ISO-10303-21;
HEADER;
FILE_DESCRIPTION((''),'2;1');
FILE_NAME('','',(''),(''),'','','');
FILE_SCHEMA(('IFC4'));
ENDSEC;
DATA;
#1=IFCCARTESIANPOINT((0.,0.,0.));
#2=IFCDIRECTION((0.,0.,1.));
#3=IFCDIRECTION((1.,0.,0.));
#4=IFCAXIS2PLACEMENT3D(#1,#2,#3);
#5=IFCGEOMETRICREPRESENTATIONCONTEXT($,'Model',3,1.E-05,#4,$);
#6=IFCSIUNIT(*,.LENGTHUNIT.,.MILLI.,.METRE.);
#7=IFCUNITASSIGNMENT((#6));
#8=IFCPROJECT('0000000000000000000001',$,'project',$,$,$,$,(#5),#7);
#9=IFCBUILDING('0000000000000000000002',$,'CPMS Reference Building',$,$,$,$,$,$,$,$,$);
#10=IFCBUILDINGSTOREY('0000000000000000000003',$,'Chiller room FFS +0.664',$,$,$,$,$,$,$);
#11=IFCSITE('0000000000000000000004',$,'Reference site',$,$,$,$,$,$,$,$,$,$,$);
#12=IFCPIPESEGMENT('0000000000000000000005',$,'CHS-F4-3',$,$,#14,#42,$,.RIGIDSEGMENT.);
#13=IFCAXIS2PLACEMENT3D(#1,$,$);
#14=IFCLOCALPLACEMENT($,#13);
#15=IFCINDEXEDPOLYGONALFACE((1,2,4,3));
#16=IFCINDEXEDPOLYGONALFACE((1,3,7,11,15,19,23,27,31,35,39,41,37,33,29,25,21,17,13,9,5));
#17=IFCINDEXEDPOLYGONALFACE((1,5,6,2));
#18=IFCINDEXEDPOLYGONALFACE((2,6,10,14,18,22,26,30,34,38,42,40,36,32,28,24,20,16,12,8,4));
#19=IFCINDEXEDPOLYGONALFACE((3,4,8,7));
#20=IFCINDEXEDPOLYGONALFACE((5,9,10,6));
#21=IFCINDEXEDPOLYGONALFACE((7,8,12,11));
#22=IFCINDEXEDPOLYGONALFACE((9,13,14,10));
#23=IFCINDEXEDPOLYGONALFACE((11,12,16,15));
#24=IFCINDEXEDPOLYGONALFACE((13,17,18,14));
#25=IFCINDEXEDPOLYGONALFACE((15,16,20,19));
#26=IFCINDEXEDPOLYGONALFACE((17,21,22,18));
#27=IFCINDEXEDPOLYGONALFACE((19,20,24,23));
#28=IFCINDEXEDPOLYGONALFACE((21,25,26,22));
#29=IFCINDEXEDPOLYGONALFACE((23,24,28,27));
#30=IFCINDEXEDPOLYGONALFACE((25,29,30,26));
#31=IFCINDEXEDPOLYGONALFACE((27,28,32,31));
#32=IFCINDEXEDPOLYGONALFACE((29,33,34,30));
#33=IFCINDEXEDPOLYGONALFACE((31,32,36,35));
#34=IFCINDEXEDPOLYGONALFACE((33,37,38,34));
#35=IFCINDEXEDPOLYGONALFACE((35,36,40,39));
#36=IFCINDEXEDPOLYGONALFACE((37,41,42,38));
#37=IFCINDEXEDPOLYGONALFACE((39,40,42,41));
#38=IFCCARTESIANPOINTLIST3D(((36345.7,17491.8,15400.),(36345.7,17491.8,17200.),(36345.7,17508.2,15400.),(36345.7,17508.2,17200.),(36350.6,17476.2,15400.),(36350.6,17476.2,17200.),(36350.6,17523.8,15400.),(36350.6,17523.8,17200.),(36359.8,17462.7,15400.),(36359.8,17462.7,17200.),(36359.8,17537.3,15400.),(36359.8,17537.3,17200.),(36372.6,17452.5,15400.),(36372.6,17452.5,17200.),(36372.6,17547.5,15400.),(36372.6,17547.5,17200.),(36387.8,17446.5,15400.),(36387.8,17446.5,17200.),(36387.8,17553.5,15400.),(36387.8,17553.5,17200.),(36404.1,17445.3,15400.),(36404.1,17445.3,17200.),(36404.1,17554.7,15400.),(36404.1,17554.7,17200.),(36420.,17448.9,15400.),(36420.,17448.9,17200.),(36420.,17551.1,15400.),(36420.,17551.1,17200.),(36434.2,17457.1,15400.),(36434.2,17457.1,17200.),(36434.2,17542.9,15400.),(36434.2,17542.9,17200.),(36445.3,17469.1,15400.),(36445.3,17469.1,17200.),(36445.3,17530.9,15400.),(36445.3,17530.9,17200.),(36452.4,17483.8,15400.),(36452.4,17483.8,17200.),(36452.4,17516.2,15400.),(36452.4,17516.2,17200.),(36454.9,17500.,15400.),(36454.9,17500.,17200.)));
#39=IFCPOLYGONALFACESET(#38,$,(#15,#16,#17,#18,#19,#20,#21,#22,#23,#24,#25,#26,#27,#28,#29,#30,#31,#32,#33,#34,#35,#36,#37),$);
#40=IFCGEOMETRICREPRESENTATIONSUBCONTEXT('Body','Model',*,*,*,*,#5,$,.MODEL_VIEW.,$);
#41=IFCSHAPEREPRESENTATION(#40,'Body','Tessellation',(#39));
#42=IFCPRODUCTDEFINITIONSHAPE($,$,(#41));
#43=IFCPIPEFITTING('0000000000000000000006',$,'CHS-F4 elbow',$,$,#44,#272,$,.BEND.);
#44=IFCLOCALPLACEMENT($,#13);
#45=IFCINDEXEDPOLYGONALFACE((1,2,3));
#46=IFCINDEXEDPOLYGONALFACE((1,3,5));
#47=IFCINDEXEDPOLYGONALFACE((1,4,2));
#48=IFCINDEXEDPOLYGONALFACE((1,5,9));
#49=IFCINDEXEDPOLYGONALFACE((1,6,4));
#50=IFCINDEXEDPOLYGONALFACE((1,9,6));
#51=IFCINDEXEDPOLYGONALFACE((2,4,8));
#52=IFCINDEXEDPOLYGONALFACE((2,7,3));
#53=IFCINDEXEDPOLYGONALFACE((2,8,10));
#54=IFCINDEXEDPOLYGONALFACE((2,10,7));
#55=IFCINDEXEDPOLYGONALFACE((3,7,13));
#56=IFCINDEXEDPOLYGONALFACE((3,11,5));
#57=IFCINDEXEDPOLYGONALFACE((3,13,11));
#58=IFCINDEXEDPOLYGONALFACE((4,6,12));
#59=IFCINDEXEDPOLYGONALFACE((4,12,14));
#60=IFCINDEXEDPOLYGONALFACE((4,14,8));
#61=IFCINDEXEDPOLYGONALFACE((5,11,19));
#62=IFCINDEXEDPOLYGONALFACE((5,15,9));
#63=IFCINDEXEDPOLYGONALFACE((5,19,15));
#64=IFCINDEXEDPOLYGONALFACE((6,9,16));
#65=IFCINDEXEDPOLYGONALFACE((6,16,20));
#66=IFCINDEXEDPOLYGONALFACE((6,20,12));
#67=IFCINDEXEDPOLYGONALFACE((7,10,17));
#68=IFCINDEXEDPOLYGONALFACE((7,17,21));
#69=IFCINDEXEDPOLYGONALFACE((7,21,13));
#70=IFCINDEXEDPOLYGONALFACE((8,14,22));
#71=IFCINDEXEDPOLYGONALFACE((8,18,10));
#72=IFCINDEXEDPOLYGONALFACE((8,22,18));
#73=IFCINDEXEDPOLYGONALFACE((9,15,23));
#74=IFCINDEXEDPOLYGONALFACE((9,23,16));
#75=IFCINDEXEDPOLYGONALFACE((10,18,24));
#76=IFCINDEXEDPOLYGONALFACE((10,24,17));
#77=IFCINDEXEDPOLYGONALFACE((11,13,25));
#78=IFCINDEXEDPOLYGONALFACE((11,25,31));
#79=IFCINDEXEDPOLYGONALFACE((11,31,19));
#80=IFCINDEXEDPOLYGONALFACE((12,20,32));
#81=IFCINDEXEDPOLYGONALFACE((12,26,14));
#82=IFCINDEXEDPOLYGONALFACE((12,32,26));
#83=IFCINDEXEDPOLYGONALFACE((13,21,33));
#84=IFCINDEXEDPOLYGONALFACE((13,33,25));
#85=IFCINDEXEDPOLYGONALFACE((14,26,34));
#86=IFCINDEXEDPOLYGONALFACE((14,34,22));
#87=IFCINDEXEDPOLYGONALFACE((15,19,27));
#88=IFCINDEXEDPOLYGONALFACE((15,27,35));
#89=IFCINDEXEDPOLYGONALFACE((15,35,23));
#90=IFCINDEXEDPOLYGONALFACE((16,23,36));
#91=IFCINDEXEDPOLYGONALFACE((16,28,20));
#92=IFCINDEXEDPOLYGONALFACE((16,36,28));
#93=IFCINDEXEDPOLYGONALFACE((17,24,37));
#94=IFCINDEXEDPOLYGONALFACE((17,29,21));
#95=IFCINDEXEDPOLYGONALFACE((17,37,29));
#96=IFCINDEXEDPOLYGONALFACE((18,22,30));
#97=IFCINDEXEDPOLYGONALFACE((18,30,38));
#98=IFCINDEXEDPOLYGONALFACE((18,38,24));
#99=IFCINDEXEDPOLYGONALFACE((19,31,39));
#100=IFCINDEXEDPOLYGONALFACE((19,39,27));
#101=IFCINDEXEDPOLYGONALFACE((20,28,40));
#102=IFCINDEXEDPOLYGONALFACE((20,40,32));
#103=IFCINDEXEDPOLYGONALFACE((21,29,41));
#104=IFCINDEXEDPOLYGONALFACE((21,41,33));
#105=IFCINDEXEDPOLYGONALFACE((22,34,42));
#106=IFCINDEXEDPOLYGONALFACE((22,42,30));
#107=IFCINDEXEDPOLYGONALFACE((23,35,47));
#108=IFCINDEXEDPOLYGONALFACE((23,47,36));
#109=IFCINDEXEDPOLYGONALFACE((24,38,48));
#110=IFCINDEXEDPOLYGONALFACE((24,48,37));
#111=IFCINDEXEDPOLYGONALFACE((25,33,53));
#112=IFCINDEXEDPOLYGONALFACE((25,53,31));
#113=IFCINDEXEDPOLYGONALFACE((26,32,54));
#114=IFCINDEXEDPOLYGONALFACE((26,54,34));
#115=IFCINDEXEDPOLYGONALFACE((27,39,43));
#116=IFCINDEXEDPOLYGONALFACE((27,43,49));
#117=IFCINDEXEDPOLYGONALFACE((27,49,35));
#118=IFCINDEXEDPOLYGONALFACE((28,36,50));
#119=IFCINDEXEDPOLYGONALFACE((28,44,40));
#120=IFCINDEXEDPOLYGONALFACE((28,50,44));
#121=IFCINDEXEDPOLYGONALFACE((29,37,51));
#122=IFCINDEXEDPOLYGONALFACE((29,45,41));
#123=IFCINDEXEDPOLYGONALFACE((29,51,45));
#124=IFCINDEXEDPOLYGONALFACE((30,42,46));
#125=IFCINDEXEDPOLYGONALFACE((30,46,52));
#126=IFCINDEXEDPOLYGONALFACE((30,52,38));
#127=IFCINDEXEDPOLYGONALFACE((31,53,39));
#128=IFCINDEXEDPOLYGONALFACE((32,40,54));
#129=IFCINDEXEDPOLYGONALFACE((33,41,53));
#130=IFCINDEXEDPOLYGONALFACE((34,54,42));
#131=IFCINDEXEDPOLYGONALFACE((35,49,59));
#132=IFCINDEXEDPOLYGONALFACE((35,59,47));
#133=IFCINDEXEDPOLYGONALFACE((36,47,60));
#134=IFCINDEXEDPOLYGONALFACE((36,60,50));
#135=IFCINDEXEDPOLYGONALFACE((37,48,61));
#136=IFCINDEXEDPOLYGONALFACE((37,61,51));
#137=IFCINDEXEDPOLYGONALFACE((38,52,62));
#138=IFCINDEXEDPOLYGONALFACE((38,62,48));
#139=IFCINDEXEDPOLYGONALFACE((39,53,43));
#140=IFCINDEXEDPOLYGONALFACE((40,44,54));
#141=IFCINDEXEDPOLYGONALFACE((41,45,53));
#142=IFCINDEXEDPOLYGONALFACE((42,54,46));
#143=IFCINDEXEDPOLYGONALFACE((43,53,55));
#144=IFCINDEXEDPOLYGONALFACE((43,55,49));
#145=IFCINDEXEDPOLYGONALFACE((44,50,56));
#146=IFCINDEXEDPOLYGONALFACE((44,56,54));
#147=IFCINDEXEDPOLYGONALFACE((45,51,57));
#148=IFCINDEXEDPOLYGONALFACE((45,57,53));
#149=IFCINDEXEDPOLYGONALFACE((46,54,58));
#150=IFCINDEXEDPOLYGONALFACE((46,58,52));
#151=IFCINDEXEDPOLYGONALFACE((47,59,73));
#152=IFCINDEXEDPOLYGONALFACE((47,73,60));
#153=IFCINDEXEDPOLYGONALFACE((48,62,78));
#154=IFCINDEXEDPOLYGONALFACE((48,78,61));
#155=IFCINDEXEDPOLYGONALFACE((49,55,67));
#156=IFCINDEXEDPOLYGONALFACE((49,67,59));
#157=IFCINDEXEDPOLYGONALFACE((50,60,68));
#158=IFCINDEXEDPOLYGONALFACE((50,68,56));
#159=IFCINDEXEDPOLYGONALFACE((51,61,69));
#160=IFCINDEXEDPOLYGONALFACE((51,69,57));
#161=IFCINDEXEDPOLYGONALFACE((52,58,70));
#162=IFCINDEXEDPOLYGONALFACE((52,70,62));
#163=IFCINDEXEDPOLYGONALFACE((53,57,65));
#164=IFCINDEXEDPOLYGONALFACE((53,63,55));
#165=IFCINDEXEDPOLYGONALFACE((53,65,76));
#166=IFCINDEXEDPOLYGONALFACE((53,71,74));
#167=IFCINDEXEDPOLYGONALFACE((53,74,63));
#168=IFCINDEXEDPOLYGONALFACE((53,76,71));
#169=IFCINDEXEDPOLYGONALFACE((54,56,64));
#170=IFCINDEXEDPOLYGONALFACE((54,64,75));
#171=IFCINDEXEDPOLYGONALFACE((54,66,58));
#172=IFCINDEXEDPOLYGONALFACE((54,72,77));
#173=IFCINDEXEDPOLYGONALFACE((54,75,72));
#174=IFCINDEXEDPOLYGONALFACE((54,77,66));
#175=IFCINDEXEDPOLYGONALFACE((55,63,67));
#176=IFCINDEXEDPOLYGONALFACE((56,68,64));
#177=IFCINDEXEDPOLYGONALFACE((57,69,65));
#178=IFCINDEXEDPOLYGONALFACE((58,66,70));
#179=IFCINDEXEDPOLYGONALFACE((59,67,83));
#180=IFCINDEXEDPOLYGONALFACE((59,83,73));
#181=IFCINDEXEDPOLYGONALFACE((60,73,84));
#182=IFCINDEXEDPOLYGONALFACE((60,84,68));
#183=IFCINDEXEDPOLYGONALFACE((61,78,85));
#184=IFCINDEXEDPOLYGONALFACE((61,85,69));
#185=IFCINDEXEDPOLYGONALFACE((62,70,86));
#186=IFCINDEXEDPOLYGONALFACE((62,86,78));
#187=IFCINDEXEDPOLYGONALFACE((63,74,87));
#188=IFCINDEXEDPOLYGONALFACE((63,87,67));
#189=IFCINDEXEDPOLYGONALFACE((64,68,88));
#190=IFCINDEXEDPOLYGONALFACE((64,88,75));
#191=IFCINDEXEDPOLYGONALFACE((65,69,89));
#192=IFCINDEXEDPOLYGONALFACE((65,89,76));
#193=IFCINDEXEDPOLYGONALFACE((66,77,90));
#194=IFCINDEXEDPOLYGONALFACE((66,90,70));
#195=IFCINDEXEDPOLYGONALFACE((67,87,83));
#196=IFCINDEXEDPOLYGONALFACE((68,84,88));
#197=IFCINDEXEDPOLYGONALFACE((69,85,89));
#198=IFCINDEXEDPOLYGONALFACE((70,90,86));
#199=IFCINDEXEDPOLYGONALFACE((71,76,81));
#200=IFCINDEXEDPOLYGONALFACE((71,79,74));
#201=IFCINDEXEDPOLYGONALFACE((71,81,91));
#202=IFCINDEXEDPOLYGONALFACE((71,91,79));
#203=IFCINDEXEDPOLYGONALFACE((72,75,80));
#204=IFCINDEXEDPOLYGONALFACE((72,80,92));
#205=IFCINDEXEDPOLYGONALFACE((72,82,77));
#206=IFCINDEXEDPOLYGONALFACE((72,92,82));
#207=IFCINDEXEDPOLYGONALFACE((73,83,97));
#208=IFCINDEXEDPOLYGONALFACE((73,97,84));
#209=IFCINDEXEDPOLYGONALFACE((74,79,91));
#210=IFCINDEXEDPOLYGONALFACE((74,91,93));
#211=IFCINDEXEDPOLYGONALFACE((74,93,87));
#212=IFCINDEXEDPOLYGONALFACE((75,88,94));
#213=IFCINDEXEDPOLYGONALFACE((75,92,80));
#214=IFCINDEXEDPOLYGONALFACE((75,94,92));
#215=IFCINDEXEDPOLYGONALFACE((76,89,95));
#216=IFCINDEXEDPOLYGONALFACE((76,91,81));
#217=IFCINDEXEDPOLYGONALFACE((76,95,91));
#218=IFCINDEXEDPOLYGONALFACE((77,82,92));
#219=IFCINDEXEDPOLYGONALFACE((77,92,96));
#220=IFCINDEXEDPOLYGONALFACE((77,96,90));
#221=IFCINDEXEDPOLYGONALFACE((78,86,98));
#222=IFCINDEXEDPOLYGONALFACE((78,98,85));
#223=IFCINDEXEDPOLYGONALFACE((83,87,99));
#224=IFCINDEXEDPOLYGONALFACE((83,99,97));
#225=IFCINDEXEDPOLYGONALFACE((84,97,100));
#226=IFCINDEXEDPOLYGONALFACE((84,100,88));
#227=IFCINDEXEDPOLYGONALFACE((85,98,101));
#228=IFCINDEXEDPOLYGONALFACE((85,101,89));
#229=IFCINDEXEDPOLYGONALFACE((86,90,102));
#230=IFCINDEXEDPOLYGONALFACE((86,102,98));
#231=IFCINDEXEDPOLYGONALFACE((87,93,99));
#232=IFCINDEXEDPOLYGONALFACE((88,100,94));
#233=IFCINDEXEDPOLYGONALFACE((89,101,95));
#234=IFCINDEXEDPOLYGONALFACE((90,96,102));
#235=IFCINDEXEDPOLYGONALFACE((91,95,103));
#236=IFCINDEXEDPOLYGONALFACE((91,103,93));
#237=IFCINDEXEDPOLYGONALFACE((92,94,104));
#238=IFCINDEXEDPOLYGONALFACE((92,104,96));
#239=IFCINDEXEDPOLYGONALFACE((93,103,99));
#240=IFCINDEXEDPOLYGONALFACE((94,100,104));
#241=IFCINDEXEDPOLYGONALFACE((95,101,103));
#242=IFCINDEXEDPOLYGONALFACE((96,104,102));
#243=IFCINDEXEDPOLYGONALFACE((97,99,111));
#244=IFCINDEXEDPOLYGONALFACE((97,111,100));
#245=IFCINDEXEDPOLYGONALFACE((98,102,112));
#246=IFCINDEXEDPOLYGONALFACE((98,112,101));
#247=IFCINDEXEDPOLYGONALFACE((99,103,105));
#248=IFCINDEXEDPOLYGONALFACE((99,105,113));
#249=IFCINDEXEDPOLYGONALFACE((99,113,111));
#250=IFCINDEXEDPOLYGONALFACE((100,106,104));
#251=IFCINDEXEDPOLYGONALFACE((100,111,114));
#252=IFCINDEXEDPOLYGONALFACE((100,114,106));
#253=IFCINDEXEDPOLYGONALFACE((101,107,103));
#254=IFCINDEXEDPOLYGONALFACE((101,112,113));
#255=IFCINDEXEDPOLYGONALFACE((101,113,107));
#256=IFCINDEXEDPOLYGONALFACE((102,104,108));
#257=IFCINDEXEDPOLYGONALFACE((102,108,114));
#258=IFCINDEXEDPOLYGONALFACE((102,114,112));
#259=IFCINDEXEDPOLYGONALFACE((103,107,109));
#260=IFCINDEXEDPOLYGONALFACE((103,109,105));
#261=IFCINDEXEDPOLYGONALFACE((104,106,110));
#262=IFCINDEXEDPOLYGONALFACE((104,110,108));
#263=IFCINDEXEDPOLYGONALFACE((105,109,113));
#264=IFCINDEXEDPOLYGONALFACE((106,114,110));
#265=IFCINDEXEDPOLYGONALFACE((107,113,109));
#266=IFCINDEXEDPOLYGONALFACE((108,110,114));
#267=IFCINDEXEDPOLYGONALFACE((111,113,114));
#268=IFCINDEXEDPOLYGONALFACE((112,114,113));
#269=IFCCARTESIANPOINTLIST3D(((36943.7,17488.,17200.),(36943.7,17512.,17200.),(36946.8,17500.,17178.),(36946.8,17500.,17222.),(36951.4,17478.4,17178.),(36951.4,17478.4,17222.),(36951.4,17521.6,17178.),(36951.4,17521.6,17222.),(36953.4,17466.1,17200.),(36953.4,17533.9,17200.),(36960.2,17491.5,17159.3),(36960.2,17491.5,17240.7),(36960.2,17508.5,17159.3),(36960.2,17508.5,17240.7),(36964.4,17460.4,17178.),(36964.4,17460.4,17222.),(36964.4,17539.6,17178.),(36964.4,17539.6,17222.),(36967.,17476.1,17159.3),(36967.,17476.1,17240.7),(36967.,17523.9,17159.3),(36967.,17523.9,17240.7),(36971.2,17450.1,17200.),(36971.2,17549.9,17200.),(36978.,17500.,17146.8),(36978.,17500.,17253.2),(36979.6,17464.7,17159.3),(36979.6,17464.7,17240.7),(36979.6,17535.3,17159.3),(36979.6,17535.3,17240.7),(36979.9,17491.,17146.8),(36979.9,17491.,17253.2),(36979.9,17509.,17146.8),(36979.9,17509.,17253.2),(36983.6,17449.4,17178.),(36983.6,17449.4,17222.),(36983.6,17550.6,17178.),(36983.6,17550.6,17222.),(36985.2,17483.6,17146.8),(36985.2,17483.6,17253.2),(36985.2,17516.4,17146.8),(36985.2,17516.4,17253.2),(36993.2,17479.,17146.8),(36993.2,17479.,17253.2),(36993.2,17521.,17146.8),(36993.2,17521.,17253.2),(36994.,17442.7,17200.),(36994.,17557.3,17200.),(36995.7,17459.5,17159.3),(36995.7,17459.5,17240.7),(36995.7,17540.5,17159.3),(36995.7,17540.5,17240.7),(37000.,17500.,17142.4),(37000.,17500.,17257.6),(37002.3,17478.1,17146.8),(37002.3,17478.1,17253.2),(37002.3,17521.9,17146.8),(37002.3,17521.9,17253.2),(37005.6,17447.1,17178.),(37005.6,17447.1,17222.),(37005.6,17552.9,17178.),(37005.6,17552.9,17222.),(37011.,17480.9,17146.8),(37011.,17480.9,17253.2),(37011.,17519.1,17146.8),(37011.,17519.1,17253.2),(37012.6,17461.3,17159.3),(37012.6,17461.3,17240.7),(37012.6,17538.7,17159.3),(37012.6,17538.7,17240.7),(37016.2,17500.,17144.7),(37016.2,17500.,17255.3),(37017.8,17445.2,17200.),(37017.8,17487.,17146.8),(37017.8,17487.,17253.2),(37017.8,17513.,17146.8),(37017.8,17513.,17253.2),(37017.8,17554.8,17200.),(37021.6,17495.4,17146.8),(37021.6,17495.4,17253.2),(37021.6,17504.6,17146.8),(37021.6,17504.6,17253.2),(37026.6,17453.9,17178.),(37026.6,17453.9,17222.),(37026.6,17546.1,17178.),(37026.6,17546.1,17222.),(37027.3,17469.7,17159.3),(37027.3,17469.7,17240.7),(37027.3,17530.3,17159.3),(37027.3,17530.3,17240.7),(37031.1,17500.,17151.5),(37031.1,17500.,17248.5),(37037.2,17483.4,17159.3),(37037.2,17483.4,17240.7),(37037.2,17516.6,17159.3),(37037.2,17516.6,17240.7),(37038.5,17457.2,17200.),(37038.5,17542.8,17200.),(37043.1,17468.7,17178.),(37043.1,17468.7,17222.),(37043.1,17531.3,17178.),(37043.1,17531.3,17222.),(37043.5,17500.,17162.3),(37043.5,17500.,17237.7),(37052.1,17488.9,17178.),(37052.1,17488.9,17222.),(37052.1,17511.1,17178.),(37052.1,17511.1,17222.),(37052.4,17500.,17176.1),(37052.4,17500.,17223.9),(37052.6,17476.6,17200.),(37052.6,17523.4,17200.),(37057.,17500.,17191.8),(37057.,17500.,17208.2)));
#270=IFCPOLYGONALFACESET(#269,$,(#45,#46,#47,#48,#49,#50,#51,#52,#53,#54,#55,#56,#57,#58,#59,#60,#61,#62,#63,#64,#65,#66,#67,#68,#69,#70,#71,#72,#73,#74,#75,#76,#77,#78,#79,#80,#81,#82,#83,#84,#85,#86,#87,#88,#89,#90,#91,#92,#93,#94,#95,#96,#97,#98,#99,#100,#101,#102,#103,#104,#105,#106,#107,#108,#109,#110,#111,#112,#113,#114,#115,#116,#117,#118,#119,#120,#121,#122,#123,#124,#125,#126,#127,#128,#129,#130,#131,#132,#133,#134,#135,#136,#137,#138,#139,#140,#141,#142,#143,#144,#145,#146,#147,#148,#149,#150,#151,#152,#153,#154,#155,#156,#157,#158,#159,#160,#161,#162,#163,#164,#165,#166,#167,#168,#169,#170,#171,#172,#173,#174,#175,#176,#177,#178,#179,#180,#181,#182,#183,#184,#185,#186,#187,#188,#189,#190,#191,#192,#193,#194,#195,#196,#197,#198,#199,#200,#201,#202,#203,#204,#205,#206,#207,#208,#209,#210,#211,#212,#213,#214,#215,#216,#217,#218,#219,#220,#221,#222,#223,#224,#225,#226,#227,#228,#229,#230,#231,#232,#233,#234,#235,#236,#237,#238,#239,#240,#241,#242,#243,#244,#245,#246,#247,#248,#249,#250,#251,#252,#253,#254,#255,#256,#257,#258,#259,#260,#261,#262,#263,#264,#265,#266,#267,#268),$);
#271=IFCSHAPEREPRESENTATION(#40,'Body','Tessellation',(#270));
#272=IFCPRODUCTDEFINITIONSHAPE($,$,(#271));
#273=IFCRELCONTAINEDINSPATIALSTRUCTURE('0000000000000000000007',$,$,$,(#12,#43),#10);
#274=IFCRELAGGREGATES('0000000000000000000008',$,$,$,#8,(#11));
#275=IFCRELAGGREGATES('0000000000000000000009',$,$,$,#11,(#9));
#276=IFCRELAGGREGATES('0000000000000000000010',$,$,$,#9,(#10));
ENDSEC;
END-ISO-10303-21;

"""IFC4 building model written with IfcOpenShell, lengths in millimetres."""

from ifc_helpers import new_model, entity, si_unit, frame, origin_with_axes, origin_2d, place, context, subcontext, project, spatial, circle_curve, outline, extrude, element, save


model = new_model("IFC4")

# Units and contexts
model_context = context("Model", 3, precision=1e-05, world=origin_with_axes())
body_context = subcontext(model_context, "Body", "Model", "MODEL_VIEW")
ifc_project = project(units=[si_unit("LENGTHUNIT", "METRE", prefix="MILLI")], contexts=[model_context])

# Site, building, storey
site = spatial("IfcSite", under=ifc_project, Name="Reference site")
building = spatial("IfcBuilding", under=site, Name="CPMS Reference Building")
storey = spatial("IfcBuildingStorey", under=building, Name="Chiller room FFS +0.664")

# Pipe segment
pipe_segment_1_placement = place(None, origin_with_axes())
element("IfcPipeSegment", 1, at=pipe_segment_1_placement, inside=storey, Name="CHS-F4-3", PredefinedType="RIGIDSEGMENT", context=body_context, shape_type="SweptSolid", body=[
    extrude(outline(circle_curve(origin_2d(), 54.9)), frame((36400.0, 17500.0, 17200.0), z_axis=(0.0, 0.0, -1.0), x_axis=(1.0, 0.0, 0.0)), (0.0, 0.0, 1.0), 1800.0),
])

# Pipe fitting
pipe_fitting_1_placement = place(None, origin_with_axes())
element("IfcPipeFitting", 2, at=pipe_fitting_1_placement, inside=storey, Name="CHS-F4 elbow", PredefinedType="BEND", context=body_context, shape_type="CSG", body=[
    entity("IfcSphere", entity("IfcAxis2Placement3D", entity("IfcCartesianPoint", [37000.0, 17500.0, 17200.0]), entity("IfcDirection", [0.0, 0.0, 1.0]), entity("IfcDirection", [1.0, 0.0, 0.0])), 57.6),
])

save(model, "model.ifc")
